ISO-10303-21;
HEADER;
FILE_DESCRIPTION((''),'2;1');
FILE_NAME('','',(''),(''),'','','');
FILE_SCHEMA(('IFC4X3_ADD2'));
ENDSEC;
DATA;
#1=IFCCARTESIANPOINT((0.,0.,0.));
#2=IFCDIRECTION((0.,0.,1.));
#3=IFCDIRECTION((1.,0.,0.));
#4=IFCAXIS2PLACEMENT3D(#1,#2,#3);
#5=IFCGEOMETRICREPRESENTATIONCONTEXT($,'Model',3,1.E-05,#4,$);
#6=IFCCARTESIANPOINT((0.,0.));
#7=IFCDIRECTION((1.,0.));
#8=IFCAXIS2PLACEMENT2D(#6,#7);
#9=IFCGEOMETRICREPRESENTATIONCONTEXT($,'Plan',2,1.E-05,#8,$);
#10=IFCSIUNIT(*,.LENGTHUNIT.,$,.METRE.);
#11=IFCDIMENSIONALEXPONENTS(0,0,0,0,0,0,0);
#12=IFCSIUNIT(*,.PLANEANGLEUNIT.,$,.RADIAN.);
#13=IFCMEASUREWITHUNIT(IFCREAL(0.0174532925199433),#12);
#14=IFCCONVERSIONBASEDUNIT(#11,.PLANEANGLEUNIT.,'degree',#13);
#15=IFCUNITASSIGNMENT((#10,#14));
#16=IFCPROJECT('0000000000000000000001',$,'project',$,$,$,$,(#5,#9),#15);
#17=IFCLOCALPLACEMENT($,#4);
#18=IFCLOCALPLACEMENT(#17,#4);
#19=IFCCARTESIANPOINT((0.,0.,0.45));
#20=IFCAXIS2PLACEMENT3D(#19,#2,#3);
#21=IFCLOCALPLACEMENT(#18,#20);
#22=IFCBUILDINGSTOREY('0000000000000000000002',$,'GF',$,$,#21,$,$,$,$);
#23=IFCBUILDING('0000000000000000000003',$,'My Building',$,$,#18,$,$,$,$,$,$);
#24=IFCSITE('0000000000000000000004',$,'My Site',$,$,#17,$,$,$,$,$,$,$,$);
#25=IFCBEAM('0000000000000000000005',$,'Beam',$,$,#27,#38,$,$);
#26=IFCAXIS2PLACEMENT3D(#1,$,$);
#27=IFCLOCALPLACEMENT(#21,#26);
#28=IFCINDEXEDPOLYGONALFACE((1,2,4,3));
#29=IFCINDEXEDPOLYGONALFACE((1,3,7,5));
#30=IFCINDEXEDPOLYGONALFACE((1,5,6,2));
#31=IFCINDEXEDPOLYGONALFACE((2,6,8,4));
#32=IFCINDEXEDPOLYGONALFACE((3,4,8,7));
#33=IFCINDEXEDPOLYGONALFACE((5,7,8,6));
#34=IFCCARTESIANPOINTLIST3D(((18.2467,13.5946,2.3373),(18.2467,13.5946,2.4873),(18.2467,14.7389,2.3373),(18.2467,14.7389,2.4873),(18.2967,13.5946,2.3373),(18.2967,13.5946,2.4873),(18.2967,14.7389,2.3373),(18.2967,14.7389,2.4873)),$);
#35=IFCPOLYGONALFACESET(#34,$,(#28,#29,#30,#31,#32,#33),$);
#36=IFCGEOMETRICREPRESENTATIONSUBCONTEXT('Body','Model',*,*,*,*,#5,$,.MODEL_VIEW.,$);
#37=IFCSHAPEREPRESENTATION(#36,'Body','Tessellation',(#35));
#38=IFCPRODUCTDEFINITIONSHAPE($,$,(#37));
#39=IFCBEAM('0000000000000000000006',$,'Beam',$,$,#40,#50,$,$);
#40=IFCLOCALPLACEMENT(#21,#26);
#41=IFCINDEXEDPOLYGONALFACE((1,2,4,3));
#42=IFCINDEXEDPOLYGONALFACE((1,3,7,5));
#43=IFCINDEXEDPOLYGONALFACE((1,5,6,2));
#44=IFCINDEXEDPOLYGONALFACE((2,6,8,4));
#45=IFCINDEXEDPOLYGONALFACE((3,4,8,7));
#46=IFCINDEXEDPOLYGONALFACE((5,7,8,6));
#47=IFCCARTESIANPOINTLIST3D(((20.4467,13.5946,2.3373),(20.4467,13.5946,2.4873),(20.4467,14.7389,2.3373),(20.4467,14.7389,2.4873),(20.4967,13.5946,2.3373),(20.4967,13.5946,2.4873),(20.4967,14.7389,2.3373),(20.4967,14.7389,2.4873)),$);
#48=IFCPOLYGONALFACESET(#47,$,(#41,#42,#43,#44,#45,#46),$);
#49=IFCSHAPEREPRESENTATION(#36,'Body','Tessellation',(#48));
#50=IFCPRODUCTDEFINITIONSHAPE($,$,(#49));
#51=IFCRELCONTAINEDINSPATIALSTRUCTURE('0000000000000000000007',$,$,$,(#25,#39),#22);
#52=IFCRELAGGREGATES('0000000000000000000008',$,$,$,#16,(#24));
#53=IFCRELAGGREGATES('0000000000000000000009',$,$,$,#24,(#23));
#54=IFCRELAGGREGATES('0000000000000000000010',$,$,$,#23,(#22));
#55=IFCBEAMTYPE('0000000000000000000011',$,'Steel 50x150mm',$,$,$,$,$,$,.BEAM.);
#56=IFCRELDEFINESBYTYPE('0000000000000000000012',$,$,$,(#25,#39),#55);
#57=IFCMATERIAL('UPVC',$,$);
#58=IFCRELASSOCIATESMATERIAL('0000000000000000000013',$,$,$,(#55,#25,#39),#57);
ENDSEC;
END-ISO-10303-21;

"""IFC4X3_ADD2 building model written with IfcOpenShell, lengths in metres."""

from ifc_helpers import new_model, entity, si_unit, converted_unit, frame, origin_with_axes, origin_2d_with_axis, place, context, subcontext, project, spatial, rectangle, extrude, material, material_profile, profile_set, profile_usage, type_object, element, save


model = new_model("IFC4X3_ADD2")

# Units and contexts
model_context = context("Model", 3, precision=1e-05, world=origin_with_axes())
plan_context = context("Plan", 2, precision=1e-05, world=origin_2d_with_axis())
body_context = subcontext(model_context, "Body", "Model", "MODEL_VIEW")
ifc_project = project(units=[si_unit("LENGTHUNIT", "METRE"), converted_unit("PLANEANGLEUNIT", "degree", entity("IfcReal", 0.0174532925199433), si_unit("PLANEANGLEUNIT", "RADIAN"), dimensions=[0, 0, 0, 0, 0, 0, 0])], contexts=[model_context, plan_context])

# Site, building, storey
site_placement = place(None, origin_with_axes())
site = spatial("IfcSite", under=ifc_project, at=site_placement, Name="My Site")
building_placement = place(site_placement, origin_with_axes())
building = spatial("IfcBuilding", under=site, at=building_placement, Name="My Building")
storey_placement = place(building_placement, frame((0.0, 0.0, 0.45), z_axis=(0.0, 0.0, 1.0), x_axis=(1.0, 0.0, 0.0)))
storey = spatial("IfcBuildingStorey", under=building, at=storey_placement, Name="GF")

# Beams
ifc_material = material(Name="UPVC")
ifc_material_profile = material_profile(ifc_material, rectangle(XDim=0.05, YDim=0.15))
ifc_profile_set = profile_set([ifc_material_profile])
beam_type = type_object("IfcBeamType", Name="Steel 50x150mm", PredefinedType="BEAM", material=ifc_profile_set)
ifc_profile_usage_1 = profile_usage(ifc_profile_set)
beam_1_placement = place(storey_placement, frame((18.2717, 14.7389, 2.4123), z_axis=(0.0, -1.0, 0.0), x_axis=(1.0, 0.0, 0.0)))
element("IfcBeam", 1, at=beam_1_placement, inside=storey, type_object=beam_type, material=ifc_profile_usage_1, Name="Beam", context=body_context, shape_type="SweptSolid", body=[
    extrude(rectangle(XDim=0.05, YDim=0.15), origin_with_axes(), (0.0, 0.0, 1.0), 1.1444),
])
ifc_profile_usage_2 = profile_usage(ifc_profile_set)
beam_2_placement = place(storey_placement, frame((20.4717, 14.7389, 2.4123), z_axis=(0.0, -1.0, 0.0), x_axis=(1.0, 0.0, 0.0)))
element("IfcBeam", 2, at=beam_2_placement, inside=storey, type_object=beam_type, material=ifc_profile_usage_2, Name="Beam", context=body_context, shape_type="SweptSolid", body=[
    extrude(rectangle(XDim=0.05, YDim=0.15), origin_with_axes(), (0.0, 0.0, 1.0), 1.1444),
])

save(model, "model.ifc")
